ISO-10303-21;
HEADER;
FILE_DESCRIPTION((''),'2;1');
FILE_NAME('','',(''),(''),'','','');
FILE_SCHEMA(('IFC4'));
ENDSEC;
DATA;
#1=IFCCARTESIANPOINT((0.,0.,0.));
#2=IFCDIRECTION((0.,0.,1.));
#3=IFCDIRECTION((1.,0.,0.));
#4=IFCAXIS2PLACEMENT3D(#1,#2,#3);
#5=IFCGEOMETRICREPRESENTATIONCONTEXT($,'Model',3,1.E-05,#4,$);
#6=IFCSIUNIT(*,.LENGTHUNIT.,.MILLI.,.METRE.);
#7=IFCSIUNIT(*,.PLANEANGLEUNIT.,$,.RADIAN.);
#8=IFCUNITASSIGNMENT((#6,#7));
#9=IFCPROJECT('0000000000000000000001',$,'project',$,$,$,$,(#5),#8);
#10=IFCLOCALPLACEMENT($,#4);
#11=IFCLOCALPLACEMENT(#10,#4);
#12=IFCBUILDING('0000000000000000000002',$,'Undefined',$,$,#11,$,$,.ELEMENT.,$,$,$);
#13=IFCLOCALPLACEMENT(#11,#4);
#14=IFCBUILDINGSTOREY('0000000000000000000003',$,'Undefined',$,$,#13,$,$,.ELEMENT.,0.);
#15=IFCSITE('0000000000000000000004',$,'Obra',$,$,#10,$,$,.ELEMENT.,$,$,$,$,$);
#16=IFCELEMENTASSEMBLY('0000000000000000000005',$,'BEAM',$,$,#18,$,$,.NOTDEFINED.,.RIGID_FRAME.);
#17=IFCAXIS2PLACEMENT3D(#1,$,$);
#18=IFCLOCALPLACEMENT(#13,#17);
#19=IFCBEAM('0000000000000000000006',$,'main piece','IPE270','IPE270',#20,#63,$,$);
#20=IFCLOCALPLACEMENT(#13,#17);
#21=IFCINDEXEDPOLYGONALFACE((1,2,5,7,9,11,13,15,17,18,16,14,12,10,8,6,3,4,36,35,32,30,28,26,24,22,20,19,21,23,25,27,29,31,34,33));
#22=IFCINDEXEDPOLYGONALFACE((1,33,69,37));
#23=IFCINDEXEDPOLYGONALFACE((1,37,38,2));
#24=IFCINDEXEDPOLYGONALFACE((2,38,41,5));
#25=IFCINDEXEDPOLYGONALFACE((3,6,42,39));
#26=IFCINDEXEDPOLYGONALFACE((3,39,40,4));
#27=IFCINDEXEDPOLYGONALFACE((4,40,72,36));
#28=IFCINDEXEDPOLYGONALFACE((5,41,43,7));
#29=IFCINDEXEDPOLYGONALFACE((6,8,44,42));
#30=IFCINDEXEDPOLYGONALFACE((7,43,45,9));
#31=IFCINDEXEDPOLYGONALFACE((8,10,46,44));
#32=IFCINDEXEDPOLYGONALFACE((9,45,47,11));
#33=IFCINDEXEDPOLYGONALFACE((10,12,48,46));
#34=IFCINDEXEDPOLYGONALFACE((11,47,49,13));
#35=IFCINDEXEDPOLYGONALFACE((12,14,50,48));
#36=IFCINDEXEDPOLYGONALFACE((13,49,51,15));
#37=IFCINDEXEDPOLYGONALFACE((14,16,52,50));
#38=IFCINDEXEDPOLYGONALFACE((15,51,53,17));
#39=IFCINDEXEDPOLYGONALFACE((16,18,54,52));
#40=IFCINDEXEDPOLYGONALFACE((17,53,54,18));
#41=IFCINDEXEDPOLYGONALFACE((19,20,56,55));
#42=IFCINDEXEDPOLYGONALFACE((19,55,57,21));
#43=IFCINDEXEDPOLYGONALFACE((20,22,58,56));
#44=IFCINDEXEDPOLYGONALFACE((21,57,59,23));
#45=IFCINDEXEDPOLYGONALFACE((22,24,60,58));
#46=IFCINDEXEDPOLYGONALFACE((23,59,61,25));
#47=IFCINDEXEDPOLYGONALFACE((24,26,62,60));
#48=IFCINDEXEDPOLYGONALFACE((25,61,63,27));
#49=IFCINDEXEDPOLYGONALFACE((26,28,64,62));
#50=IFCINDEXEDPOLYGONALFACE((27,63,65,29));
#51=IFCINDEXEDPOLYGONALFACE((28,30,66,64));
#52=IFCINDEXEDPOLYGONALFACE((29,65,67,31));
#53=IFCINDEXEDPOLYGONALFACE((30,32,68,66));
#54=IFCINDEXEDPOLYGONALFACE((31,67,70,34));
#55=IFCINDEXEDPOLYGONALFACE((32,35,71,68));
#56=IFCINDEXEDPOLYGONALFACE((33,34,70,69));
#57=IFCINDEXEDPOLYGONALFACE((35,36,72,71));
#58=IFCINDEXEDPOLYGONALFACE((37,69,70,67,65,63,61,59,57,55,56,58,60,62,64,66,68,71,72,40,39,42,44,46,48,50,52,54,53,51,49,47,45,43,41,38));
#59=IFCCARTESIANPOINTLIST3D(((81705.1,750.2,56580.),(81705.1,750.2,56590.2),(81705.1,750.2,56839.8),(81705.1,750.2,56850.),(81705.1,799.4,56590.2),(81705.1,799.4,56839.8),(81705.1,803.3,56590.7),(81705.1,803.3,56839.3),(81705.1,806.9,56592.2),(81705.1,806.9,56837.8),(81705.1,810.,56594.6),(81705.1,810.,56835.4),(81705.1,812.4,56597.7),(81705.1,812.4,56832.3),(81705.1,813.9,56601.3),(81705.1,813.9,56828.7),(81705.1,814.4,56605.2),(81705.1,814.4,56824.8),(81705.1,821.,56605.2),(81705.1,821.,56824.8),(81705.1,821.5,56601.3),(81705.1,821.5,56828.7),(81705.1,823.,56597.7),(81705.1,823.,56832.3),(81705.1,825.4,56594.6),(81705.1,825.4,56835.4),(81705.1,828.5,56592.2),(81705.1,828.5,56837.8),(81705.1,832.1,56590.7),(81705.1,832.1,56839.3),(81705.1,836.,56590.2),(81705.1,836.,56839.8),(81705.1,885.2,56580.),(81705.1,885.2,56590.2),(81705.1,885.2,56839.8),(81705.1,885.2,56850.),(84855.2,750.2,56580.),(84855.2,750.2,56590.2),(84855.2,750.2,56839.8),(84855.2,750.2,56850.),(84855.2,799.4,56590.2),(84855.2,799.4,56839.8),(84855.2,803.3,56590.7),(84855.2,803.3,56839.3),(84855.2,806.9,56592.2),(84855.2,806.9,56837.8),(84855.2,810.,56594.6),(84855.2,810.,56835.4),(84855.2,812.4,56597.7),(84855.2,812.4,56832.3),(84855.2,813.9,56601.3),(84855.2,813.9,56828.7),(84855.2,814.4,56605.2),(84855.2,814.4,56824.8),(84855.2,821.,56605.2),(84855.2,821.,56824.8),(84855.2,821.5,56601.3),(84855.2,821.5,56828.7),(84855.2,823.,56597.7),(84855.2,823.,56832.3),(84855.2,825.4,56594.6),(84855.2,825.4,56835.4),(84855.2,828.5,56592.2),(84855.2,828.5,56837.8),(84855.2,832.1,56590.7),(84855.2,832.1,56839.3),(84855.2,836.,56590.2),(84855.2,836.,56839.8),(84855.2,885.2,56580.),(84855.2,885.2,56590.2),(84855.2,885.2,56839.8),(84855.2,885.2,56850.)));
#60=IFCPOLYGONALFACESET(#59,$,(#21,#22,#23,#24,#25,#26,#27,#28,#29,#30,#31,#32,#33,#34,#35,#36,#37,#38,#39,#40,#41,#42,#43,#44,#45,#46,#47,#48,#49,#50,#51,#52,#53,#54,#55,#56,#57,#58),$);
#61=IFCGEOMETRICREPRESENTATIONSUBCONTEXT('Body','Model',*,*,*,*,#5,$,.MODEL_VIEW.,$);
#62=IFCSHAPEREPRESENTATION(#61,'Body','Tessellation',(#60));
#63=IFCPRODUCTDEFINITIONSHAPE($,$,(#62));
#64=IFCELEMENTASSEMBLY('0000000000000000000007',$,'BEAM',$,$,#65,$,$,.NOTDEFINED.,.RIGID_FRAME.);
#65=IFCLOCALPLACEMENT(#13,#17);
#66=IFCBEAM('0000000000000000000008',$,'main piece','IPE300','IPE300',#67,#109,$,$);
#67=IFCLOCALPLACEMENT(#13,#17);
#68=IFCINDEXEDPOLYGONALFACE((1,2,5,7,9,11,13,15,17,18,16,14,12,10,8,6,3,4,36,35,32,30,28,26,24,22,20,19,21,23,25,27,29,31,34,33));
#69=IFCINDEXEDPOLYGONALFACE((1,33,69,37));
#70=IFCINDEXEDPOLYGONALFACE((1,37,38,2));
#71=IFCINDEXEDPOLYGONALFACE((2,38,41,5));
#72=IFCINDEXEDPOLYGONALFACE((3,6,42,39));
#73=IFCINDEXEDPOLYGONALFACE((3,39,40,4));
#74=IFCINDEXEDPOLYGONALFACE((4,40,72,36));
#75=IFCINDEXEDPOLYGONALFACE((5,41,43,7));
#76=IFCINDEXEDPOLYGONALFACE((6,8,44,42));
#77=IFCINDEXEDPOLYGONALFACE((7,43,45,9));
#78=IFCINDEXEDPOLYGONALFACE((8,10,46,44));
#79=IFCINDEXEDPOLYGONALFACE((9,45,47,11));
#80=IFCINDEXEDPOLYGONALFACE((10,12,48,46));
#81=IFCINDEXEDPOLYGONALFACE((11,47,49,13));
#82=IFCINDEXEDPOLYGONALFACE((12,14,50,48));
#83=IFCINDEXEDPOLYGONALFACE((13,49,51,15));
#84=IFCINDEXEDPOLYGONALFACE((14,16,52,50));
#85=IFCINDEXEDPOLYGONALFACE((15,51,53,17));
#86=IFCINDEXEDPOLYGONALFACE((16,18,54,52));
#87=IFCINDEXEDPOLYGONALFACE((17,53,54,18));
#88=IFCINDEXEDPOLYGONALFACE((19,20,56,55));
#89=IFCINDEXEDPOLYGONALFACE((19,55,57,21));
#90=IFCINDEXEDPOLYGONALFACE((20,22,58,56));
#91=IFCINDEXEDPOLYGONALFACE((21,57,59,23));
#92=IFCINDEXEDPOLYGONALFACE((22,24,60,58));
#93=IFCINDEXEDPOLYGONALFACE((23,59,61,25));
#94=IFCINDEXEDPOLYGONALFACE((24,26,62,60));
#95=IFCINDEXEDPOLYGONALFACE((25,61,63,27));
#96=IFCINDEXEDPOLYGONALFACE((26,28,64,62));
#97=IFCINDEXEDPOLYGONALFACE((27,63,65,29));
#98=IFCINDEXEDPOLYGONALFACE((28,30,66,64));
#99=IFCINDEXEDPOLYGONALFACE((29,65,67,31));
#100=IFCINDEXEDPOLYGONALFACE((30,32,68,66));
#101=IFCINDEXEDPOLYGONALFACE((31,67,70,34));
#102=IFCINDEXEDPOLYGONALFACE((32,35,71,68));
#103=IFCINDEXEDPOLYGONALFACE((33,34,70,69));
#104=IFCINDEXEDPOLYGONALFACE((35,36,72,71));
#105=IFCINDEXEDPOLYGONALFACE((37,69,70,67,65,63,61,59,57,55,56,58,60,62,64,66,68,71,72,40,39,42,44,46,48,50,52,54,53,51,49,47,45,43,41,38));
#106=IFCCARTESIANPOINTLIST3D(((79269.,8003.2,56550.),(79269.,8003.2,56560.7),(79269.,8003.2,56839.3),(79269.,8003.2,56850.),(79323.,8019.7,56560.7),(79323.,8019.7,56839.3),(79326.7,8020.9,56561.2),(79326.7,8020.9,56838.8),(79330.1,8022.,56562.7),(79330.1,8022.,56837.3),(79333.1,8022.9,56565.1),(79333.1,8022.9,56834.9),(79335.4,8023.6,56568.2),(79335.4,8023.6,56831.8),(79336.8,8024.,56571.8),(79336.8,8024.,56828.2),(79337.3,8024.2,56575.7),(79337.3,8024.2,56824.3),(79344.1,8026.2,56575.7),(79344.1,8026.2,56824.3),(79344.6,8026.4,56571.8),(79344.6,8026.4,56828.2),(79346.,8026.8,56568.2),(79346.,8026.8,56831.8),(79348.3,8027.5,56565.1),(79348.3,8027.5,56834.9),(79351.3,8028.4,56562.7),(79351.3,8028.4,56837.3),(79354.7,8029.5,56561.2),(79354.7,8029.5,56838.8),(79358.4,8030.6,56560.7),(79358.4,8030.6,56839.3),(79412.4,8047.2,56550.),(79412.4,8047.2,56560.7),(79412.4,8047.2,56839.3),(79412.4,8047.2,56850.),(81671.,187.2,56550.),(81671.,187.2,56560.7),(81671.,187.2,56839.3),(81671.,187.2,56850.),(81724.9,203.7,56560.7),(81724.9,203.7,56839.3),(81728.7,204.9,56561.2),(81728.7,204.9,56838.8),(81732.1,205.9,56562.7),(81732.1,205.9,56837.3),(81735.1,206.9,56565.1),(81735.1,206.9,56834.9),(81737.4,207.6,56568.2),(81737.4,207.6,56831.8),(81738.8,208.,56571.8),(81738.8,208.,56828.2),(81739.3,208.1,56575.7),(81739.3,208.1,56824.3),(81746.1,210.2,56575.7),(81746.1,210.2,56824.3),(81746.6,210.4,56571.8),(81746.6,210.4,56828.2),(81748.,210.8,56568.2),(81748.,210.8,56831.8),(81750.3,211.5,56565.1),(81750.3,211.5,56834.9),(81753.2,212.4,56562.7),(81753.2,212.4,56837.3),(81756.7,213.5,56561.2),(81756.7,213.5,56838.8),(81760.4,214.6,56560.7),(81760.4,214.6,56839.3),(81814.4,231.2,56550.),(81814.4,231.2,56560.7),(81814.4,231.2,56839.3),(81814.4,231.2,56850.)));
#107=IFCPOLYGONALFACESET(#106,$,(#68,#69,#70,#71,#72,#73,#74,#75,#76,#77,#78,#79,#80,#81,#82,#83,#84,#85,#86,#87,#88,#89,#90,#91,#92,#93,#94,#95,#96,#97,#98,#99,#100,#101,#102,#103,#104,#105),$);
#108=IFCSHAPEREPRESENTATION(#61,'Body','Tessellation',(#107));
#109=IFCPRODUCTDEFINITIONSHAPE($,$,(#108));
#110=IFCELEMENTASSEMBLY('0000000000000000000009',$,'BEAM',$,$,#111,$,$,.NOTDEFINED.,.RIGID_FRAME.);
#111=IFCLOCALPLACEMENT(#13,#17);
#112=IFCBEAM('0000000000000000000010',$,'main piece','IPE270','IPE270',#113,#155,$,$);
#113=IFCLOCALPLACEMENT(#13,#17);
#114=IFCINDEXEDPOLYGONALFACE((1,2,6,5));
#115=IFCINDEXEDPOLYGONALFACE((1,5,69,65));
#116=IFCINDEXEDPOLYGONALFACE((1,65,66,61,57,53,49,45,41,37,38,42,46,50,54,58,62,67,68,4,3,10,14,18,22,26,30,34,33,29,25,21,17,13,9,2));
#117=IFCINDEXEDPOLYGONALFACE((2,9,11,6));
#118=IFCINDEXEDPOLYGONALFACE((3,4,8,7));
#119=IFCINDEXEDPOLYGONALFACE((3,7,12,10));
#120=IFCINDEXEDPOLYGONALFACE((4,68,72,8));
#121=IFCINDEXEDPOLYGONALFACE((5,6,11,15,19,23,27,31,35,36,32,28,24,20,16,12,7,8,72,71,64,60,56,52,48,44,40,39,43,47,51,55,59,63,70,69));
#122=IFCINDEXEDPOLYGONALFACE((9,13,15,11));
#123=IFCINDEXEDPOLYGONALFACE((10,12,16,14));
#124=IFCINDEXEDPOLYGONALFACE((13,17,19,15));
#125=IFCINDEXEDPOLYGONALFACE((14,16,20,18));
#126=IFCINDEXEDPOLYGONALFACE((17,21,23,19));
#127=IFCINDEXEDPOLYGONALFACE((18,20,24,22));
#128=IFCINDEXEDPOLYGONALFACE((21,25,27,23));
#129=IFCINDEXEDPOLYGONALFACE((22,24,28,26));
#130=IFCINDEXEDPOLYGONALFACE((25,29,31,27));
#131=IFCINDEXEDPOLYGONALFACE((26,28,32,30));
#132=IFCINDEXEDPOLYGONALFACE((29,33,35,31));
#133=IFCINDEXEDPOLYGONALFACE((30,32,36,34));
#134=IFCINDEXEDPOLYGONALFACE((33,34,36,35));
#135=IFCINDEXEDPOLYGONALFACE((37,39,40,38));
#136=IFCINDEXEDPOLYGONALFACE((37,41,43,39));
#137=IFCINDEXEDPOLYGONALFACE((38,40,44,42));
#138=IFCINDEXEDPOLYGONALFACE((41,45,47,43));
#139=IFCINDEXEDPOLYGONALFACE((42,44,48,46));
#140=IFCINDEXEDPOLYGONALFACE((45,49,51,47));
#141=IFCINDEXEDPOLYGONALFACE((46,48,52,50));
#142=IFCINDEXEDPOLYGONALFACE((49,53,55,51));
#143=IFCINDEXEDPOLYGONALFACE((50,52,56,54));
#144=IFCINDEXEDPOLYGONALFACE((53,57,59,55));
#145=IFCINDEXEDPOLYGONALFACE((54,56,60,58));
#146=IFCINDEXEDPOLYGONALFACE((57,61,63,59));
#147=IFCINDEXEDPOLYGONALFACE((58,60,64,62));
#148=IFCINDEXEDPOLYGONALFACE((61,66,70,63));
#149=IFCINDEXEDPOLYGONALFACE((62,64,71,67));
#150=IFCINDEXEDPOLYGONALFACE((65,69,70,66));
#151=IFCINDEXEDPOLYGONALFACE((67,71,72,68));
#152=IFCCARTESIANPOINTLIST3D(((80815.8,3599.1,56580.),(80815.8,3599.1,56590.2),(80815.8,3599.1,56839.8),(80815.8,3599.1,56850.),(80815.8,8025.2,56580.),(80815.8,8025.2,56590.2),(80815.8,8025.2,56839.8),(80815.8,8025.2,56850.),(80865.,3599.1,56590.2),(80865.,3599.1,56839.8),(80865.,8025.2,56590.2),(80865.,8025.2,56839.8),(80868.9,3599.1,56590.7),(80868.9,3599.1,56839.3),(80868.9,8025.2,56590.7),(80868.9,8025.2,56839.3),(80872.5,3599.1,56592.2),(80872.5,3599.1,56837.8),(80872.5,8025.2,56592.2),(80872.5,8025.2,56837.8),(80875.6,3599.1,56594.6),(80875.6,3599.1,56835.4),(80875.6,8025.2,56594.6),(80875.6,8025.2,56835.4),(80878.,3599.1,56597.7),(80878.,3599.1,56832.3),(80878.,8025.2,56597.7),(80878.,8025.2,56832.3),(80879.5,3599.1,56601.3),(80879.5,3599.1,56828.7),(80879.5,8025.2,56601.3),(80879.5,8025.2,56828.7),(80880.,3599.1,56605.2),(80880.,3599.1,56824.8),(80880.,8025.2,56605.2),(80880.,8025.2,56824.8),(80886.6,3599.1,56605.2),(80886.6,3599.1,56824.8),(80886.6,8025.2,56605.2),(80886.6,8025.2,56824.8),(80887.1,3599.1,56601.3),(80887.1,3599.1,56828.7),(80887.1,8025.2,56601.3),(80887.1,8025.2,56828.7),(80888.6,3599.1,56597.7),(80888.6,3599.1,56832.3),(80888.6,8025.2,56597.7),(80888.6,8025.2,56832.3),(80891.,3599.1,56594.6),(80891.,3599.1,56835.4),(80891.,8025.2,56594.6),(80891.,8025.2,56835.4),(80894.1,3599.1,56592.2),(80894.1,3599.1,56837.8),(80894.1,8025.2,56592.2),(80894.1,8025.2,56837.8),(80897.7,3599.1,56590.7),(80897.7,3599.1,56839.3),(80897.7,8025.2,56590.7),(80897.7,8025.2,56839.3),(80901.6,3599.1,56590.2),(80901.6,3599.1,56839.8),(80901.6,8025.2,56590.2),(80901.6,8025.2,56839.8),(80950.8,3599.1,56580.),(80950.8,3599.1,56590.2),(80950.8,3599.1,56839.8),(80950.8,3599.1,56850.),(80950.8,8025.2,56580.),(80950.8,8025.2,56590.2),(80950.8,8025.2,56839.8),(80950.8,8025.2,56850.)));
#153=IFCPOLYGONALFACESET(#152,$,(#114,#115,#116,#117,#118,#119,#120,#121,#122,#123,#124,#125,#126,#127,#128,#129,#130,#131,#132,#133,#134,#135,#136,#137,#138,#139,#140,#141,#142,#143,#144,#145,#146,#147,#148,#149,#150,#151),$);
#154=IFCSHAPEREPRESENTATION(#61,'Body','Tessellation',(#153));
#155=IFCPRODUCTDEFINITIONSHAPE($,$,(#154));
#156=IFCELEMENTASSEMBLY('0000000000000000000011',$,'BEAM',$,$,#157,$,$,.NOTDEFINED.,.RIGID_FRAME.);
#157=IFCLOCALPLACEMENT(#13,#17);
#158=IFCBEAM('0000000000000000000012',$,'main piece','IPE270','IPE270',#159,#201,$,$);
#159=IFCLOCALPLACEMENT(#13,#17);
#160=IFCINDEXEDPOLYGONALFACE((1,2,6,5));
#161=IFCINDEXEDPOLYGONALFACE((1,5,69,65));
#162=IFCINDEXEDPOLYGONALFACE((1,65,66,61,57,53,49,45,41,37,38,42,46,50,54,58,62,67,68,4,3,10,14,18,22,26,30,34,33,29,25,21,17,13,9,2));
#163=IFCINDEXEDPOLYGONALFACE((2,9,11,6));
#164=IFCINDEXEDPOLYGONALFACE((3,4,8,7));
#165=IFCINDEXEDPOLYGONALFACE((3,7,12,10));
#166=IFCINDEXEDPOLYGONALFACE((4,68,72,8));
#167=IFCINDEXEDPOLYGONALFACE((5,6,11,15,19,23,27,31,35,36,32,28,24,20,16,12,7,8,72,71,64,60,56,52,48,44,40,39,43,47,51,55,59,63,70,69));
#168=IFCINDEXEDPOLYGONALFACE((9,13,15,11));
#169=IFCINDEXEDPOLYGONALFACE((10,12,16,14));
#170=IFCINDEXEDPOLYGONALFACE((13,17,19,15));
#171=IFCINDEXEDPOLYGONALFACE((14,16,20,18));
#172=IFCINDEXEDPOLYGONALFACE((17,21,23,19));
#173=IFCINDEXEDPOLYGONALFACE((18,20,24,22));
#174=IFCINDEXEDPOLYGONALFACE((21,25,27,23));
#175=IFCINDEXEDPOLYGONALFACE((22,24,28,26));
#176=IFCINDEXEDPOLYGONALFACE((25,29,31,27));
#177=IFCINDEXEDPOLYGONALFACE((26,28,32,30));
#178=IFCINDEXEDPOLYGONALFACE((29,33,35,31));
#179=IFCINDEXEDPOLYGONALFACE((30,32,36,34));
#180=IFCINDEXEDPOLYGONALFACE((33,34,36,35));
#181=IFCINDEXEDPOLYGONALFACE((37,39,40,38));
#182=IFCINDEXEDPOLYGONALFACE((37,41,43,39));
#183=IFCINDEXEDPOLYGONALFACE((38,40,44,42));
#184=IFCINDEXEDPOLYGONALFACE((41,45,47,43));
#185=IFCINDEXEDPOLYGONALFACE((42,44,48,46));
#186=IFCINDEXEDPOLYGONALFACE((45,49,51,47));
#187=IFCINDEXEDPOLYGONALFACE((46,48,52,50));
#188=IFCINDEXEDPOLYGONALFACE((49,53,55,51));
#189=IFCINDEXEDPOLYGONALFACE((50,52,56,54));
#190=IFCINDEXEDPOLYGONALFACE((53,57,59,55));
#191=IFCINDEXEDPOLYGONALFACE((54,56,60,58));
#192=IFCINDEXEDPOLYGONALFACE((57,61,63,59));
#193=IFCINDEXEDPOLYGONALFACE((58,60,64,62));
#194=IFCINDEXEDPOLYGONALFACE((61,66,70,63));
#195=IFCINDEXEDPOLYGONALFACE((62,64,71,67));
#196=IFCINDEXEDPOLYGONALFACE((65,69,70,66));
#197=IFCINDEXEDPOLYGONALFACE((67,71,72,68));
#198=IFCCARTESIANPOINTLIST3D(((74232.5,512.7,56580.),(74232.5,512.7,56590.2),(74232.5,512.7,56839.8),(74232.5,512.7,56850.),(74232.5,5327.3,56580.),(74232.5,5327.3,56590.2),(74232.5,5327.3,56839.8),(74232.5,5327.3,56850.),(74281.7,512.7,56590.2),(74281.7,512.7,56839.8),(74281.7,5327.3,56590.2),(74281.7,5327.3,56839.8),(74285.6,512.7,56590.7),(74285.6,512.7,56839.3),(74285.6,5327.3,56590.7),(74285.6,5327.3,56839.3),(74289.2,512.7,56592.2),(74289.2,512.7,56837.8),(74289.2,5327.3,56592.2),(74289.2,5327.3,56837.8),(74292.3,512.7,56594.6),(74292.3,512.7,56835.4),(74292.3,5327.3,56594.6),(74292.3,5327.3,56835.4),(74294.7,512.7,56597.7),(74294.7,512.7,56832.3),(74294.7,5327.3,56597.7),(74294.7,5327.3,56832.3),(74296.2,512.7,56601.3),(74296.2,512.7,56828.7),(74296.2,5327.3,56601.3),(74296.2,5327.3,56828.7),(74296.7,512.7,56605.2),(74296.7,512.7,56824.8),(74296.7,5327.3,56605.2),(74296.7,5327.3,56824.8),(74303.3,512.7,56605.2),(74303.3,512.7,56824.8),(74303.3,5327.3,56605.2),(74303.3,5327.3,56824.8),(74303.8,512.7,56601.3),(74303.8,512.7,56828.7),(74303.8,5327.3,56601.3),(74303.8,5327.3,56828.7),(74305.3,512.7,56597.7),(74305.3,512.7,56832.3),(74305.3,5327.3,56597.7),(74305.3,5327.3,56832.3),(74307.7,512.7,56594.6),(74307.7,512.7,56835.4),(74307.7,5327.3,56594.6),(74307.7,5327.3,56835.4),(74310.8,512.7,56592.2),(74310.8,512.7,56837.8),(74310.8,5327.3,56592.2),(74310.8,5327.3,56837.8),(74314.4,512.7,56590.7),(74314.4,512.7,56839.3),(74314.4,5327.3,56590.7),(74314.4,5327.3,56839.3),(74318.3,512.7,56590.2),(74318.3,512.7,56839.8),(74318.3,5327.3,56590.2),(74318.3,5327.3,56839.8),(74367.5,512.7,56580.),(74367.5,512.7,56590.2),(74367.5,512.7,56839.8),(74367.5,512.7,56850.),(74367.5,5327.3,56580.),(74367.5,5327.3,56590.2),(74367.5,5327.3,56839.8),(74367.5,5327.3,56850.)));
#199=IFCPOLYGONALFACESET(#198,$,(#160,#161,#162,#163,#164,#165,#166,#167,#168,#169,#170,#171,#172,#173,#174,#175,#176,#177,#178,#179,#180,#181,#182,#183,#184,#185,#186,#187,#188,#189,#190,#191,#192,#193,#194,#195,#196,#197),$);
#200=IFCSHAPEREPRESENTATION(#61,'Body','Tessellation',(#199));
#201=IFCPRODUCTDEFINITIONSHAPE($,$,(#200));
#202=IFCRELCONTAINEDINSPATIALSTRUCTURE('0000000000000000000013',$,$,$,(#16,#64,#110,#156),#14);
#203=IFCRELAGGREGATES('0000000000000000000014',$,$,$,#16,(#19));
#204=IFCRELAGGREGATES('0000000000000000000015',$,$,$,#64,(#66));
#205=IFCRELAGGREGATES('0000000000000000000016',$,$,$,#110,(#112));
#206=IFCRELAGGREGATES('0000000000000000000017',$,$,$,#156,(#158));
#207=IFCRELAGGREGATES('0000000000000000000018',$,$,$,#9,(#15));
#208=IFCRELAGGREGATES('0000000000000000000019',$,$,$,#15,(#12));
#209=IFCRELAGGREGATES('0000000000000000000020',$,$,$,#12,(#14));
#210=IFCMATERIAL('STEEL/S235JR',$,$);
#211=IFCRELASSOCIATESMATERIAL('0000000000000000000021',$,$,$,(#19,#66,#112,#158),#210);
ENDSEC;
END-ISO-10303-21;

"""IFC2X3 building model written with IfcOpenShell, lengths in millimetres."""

from ifc_helpers import new_model, si_unit, frame, origin_with_axes, origin_2d_with_axis, place, context, subcontext, project, spatial, i_section, extrude, material, element, aggregate, save


model = new_model("IFC2X3")

# Units and contexts
model_context = context("Model", 3, precision=1e-05, world=origin_with_axes())
body_context = subcontext(model_context, "Body", "Model", "MODEL_VIEW")
ifc_project = project(units=[si_unit("LENGTHUNIT", "METRE", prefix="MILLI"), si_unit("PLANEANGLEUNIT", "RADIAN")], contexts=[model_context])

# Site, building, storey
site_placement = place(None, origin_with_axes())
site = spatial("IfcSite", under=ifc_project, at=site_placement, Name="Obra", CompositionType="ELEMENT")
building_placement = place(site_placement, origin_with_axes())
building = spatial("IfcBuilding", under=site, at=building_placement, Name="Undefined", CompositionType="ELEMENT")
storey_placement = place(building_placement, origin_with_axes())
storey = spatial("IfcBuildingStorey", under=building, at=storey_placement, Name="Undefined", CompositionType="ELEMENT", Elevation=0.0)

# Shared definitions
ifc_material_1 = material(Name="STEEL/S235JR")

# Element assemblies, beams
assembly_1_placement = place(storey_placement, origin_with_axes())
assembly_1 = element("IfcElementAssembly", 1, at=assembly_1_placement, inside=storey, Name="BEAM", AssemblyPlace="NOTDEFINED", PredefinedType="RIGID_FRAME")
beam_1_placement = place(assembly_1_placement, frame((81705.1, 817.7, 56715.0), z_axis=(0.0, 0.0, 1.0), x_axis=(1.0, 0.0, 0.0)))
beam_1 = element("IfcBeam", 2, at=beam_1_placement, material=ifc_material_1, Name="main piece", Description="IPE270", ObjectType="IPE270", context=body_context, shape_type="SweptSolid", body=[
    extrude(i_section(OverallWidth=135.0, OverallDepth=270.0, WebThickness=6.6, FlangeThickness=10.2, FilletRadius=15.0, at=origin_2d_with_axis()), frame((3150.0, 0.0, 0.0), z_axis=(-1.0, 0.0, 0.0), x_axis=(0.0, -1.0, 0.0)), (0.0, 0.0, 1.0), 3150.0),
])
aggregate(assembly_1, [beam_1])
assembly_2_placement = place(storey_placement, origin_with_axes())
assembly_2 = element("IfcElementAssembly", 3, at=assembly_2_placement, inside=storey, Name="BEAM", AssemblyPlace="NOTDEFINED", PredefinedType="RIGID_FRAME")
beam_2_placement = place(assembly_2_placement, frame((79340.7, 8025.2, 56700.0), z_axis=(0.0, 0.0, 1.0), x_axis=(0.293756, -0.955881, 0.0)))
beam_2 = element("IfcBeam", 4, at=beam_2_placement, material=ifc_material_1, Name="main piece", Description="IPE300", ObjectType="IPE300", context=body_context, shape_type="SweptSolid", body=[
    extrude(i_section(OverallWidth=150.0, OverallDepth=300.0, WebThickness=7.1, FlangeThickness=10.7, FilletRadius=15.0, at=origin_2d_with_axis()), frame((8176.8, 0.0, 0.0), z_axis=(-1.0, 0.0, 0.0), x_axis=(0.0, -1.0, 0.0)), (0.0, 0.0, 1.0), 8176.8),
])
aggregate(assembly_2, [beam_2])
assembly_3_placement = place(storey_placement, origin_with_axes())
assembly_3 = element("IfcElementAssembly", 5, at=assembly_3_placement, inside=storey, Name="BEAM", AssemblyPlace="NOTDEFINED", PredefinedType="RIGID_FRAME")
beam_3_placement = place(assembly_3_placement, frame((80883.3, 3599.1, 56715.0), z_axis=(0.0, 0.0, 1.0), x_axis=(0.0, 1.0, 0.0)))
beam_3 = element("IfcBeam", 6, at=beam_3_placement, material=ifc_material_1, Name="main piece", Description="IPE270", ObjectType="IPE270", context=body_context, shape_type="SweptSolid", body=[
    extrude(i_section(OverallWidth=135.0, OverallDepth=270.0, WebThickness=6.6, FlangeThickness=10.2, FilletRadius=15.0, at=origin_2d_with_axis()), frame((4426.1, 0.0, 0.0), z_axis=(-1.0, 0.0, 0.0), x_axis=(0.0, -1.0, 0.0)), (0.0, 0.0, 1.0), 4426.1),
])
aggregate(assembly_3, [beam_3])
assembly_4_placement = place(storey_placement, origin_with_axes())
assembly_4 = element("IfcElementAssembly", 7, at=assembly_4_placement, inside=storey, Name="BEAM", AssemblyPlace="NOTDEFINED", PredefinedType="RIGID_FRAME")
beam_4_placement = place(assembly_4_placement, frame((74300.0, 512.7, 56715.0), z_axis=(0.0, 0.0, 1.0), x_axis=(0.0, 1.0, 0.0)))
beam_4 = element("IfcBeam", 8, at=beam_4_placement, material=ifc_material_1, Name="main piece", Description="IPE270", ObjectType="IPE270", context=body_context, shape_type="SweptSolid", body=[
    extrude(i_section(OverallWidth=135.0, OverallDepth=270.0, WebThickness=6.6, FlangeThickness=10.2, FilletRadius=15.0, at=origin_2d_with_axis()), frame((4814.6, 0.0, 0.0), z_axis=(-1.0, 0.0, 0.0), x_axis=(0.0, -1.0, 0.0)), (0.0, 0.0, 1.0), 4814.6),
])
aggregate(assembly_4, [beam_4])

save(model, "model.ifc")
